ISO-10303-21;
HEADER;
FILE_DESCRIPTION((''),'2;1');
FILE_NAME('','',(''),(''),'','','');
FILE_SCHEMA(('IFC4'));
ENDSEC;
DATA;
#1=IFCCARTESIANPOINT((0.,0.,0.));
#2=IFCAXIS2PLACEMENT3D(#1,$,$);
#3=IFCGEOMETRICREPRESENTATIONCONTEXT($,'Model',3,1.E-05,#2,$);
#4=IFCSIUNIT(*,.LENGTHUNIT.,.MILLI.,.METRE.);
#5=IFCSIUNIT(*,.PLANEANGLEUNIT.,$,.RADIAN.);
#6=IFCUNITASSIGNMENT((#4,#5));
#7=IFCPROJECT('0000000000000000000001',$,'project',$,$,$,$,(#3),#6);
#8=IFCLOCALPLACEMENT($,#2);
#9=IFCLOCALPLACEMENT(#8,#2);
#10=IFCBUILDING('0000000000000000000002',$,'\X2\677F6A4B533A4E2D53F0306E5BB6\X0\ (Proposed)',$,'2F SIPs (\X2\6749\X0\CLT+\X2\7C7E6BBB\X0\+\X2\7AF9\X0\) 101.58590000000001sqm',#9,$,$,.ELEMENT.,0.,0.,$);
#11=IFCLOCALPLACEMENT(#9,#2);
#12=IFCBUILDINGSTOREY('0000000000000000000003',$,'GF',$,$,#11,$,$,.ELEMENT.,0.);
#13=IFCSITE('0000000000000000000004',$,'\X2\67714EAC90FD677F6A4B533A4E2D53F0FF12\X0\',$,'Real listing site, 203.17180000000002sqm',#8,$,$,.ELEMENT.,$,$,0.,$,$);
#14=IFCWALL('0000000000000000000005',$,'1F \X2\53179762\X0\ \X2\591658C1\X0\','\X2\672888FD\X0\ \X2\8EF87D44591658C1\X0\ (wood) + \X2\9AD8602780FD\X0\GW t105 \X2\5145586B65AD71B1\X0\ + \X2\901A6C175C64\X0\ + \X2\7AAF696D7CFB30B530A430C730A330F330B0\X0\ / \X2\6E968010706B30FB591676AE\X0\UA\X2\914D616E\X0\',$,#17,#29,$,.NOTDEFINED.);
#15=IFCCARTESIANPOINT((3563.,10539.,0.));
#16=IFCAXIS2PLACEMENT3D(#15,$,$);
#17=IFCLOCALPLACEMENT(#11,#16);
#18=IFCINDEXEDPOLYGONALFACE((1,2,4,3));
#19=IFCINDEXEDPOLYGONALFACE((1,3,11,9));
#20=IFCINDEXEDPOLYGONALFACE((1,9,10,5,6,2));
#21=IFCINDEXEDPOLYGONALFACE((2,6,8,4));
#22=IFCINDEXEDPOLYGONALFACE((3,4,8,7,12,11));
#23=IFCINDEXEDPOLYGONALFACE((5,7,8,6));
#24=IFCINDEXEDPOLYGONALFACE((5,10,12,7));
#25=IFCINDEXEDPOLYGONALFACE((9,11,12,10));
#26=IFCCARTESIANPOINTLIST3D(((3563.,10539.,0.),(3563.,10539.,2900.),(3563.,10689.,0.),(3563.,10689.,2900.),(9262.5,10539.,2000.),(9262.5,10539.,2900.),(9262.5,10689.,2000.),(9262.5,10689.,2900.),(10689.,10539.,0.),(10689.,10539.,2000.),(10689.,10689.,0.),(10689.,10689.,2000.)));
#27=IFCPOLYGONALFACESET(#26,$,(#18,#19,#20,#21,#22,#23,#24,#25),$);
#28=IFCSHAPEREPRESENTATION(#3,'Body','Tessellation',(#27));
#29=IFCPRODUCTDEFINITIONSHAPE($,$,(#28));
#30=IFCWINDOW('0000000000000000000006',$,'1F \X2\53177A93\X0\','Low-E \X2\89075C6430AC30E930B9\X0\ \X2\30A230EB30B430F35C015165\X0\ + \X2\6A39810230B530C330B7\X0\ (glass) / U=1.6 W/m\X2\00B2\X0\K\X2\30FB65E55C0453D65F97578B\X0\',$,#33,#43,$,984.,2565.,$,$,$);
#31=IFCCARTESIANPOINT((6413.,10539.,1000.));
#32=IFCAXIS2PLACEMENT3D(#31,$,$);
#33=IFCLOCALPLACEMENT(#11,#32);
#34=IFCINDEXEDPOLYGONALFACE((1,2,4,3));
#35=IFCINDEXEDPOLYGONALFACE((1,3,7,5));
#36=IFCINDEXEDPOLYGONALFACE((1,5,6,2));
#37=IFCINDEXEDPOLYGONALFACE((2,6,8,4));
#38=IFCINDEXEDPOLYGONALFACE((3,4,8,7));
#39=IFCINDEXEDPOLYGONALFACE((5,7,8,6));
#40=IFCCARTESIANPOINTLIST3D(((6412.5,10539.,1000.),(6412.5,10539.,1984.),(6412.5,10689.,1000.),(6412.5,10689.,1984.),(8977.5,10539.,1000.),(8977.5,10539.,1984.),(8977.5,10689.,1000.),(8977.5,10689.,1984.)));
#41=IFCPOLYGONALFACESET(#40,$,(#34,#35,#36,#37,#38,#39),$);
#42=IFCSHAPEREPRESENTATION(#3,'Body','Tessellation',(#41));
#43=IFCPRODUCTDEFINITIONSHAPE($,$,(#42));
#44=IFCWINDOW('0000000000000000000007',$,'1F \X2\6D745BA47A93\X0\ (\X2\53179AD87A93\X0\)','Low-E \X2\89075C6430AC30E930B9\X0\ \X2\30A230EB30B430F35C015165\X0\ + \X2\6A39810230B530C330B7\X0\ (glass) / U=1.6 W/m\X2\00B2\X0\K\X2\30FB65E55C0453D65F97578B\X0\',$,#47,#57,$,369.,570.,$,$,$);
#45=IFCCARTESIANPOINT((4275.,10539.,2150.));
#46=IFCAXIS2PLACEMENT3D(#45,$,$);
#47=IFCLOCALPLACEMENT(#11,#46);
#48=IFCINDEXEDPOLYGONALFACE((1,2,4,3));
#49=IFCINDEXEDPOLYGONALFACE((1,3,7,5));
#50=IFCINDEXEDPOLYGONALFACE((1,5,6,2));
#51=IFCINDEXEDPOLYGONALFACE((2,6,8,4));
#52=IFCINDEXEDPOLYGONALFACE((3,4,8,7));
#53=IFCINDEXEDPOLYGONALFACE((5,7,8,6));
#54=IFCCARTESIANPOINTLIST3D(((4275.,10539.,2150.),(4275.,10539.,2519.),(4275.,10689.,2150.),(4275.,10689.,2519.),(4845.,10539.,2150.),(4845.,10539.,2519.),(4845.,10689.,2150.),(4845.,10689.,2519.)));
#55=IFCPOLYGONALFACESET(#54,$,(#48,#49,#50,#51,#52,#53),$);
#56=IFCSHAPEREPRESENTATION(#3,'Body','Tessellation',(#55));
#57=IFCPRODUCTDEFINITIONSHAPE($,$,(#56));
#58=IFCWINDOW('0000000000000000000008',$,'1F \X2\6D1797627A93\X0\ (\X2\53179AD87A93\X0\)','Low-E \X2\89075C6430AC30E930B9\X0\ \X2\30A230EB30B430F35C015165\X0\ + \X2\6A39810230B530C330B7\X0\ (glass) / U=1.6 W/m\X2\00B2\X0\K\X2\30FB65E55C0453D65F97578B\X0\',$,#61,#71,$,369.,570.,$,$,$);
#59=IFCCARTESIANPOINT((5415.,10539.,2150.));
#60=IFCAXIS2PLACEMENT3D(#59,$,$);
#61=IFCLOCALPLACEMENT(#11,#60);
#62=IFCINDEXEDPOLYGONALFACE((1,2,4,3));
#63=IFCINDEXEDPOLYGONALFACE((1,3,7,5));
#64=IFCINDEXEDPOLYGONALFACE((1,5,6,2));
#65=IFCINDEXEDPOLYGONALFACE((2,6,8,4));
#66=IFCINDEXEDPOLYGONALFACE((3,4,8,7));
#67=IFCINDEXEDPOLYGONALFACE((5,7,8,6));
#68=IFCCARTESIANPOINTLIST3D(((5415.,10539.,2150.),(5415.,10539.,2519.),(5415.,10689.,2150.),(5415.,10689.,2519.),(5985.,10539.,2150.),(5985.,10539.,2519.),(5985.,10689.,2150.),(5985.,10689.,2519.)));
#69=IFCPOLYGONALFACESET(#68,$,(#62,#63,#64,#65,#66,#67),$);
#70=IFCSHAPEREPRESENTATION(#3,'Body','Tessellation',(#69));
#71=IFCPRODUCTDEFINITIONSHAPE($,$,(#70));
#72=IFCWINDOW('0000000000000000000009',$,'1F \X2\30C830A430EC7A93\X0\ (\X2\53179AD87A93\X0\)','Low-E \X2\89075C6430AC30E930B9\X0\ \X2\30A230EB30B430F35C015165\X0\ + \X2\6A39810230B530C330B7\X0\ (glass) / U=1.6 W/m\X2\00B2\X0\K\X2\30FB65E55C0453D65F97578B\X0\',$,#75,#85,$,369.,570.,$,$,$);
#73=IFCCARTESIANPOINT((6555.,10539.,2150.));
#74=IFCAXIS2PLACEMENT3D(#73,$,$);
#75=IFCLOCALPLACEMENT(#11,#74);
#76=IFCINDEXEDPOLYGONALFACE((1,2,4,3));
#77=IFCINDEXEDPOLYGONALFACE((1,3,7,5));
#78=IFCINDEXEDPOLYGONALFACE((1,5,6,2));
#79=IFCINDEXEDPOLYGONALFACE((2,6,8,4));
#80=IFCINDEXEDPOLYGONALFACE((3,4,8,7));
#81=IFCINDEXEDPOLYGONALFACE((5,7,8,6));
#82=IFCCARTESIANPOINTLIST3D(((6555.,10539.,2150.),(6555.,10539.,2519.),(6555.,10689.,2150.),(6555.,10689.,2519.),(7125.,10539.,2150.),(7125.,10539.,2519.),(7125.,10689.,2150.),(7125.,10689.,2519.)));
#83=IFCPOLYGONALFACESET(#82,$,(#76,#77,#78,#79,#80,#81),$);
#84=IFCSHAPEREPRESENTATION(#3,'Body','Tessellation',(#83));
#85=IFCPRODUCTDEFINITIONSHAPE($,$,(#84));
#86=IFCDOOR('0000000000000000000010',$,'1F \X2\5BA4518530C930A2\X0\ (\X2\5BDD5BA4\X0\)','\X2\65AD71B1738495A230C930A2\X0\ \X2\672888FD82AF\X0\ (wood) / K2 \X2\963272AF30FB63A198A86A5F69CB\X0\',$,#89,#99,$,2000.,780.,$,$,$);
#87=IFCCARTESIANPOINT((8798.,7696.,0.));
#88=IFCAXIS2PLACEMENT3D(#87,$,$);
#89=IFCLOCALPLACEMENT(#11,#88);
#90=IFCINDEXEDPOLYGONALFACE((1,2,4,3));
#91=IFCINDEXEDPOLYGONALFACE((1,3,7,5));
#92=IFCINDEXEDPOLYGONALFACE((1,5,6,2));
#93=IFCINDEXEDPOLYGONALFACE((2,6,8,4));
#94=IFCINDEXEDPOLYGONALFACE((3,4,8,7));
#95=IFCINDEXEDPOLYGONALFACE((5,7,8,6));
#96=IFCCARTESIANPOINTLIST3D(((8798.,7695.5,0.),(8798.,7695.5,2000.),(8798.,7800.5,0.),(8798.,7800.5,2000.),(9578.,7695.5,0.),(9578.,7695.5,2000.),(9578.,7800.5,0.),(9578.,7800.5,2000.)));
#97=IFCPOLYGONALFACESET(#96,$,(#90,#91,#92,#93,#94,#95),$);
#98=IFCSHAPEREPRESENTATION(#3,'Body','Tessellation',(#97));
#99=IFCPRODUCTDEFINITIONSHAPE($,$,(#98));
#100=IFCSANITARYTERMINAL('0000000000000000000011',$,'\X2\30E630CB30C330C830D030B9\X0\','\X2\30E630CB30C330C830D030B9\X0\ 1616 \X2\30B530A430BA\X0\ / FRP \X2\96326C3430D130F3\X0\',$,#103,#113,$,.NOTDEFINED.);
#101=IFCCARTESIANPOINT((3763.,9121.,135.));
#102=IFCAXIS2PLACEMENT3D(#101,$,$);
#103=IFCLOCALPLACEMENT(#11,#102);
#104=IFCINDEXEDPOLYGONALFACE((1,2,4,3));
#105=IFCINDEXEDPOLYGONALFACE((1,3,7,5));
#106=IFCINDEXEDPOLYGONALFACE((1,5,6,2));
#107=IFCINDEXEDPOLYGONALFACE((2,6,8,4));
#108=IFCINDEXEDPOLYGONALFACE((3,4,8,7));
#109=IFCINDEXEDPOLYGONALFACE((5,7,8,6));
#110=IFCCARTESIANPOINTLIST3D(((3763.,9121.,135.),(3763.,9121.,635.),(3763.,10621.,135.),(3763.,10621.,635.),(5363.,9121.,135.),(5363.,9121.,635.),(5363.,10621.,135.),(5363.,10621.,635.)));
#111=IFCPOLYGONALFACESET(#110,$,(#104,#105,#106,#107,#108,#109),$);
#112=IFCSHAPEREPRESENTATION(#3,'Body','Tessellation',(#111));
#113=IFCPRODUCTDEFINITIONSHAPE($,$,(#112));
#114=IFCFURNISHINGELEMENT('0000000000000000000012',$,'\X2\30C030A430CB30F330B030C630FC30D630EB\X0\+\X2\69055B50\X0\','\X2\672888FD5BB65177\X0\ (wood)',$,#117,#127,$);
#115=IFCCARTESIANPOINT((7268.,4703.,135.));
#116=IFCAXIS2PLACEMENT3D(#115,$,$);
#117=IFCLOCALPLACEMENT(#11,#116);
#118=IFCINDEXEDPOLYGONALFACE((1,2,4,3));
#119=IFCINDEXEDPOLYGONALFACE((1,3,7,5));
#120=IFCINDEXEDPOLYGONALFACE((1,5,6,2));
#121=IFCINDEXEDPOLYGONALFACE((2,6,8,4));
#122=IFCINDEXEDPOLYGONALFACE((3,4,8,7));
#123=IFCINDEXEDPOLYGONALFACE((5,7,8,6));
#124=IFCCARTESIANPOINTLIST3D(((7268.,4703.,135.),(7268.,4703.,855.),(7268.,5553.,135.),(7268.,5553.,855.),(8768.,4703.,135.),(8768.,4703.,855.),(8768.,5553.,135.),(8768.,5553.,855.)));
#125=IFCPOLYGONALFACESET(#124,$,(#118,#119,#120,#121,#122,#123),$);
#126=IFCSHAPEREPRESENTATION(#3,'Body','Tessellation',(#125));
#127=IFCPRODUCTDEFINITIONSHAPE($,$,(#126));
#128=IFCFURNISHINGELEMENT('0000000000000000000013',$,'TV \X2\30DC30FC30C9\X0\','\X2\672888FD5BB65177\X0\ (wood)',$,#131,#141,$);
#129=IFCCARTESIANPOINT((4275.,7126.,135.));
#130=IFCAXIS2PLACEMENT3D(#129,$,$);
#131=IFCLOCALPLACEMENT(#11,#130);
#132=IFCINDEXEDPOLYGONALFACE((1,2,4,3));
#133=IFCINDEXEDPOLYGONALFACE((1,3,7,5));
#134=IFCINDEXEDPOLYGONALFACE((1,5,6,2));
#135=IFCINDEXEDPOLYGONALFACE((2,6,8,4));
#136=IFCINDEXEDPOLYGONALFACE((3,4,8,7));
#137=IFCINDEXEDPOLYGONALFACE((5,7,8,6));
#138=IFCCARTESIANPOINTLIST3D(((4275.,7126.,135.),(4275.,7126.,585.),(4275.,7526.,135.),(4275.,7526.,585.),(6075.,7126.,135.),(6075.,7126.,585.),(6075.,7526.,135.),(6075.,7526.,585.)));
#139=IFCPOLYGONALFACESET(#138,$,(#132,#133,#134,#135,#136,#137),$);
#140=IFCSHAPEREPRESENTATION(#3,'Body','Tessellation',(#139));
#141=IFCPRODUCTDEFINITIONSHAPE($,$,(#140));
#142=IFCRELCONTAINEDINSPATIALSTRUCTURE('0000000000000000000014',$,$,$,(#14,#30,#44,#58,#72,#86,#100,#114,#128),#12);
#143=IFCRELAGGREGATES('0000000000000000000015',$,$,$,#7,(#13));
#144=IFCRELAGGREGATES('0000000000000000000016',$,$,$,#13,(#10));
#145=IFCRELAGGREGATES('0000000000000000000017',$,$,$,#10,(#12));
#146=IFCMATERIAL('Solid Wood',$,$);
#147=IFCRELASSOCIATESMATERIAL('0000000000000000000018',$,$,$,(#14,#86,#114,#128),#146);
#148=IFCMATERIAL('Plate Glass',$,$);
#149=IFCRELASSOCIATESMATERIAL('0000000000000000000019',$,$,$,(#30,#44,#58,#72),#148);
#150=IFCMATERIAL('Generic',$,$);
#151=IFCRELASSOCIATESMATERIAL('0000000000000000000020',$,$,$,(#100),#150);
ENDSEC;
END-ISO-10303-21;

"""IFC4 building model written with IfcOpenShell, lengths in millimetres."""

from ifc_helpers import new_model, si_unit, frame, frame_2d, origin, place, context, project, spatial, rectangle, extrude, material, element, fill, save


model = new_model("IFC4")

# Units and contexts
model_context = context("Model", 3, precision=1e-05, world=origin())
ifc_project = project(units=[si_unit("LENGTHUNIT", "METRE", prefix="MILLI"), si_unit("PLANEANGLEUNIT", "RADIAN")], contexts=[model_context])

# Site, building, storey
site_placement = place(None, origin())
site = spatial("IfcSite", under=ifc_project, at=site_placement, Name="東京都板橋区中台２", ObjectType="Real listing site, 203.17180000000002sqm", CompositionType="ELEMENT", RefElevation=0.0)
building_placement = place(site_placement, origin())
building = spatial("IfcBuilding", under=site, at=building_placement, Name="板橋区中台の家 (Proposed)", ObjectType="2F SIPs (杉CLT+籾殻+竹) 101.58590000000001sqm", CompositionType="ELEMENT", ElevationOfRefHeight=0.0, ElevationOfTerrain=0.0)
storey_placement = place(building_placement, origin())
storey = spatial("IfcBuildingStorey", under=building, at=storey_placement, Name="GF", CompositionType="ELEMENT", Elevation=0.0)

# Wall, openings, windows
ifc_material_1 = material(Name="Solid Wood")
wall_1_placement = place(storey_placement, frame((3563.0, 10539.0, 0.0)))
wall_1 = element("IfcWall", 1, at=wall_1_placement, inside=storey, material=ifc_material_1, Name="1F 北面 外壁", Description="木製 軸組外壁 (wood) + 高性能GW t105 充填断熱 + 通気層 + 窯業系サイディング / 準耐火・外皮UA配慮", PredefinedType="NOTDEFINED", context=model_context, shape_type="SweptSolid", body=[
    extrude(rectangle(XDim=7126.0, YDim=150.0, at=frame_2d((3563.0, 75.0))), frame((3563.0, 10539.0, 0.0)), (0.0, 0.0, 1.0), 2900.0),
])
opening_1_placement = place(storey_placement, frame((6413.0, 10539.0, 1000.0)))
opening_1 = element("IfcOpeningElement", 2, at=opening_1_placement, cuts=wall_1, PredefinedType="NOTDEFINED", context=model_context, shape_type="SweptSolid", body=[
    extrude(rectangle(XDim=2565.0, YDim=150.0, at=frame_2d((1282.0, 75.0))), frame((6413.0, 10539.0, 1000.0)), (0.0, 0.0, 1.0), 984.0),
])
opening_2_placement = place(storey_placement, frame((4275.0, 10539.0, 2150.0)))
opening_2 = element("IfcOpeningElement", 3, at=opening_2_placement, cuts=wall_1, PredefinedType="NOTDEFINED", context=model_context, shape_type="SweptSolid", body=[
    extrude(rectangle(XDim=570.0, YDim=150.0, at=frame_2d((285.0, 75.0))), frame((4275.0, 10539.0, 2150.0)), (0.0, 0.0, 1.0), 369.0),
])
opening_3_placement = place(storey_placement, frame((5415.0, 10539.0, 2150.0)))
opening_3 = element("IfcOpeningElement", 4, at=opening_3_placement, cuts=wall_1, PredefinedType="NOTDEFINED", context=model_context, shape_type="SweptSolid", body=[
    extrude(rectangle(XDim=570.0, YDim=150.0, at=frame_2d((285.0, 75.0))), frame((5415.0, 10539.0, 2150.0)), (0.0, 0.0, 1.0), 369.0),
])
opening_4_placement = place(storey_placement, frame((6555.0, 10539.0, 2150.0)))
opening_4 = element("IfcOpeningElement", 5, at=opening_4_placement, cuts=wall_1, PredefinedType="NOTDEFINED", context=model_context, shape_type="SweptSolid", body=[
    extrude(rectangle(XDim=570.0, YDim=150.0, at=frame_2d((285.0, 75.0))), frame((6555.0, 10539.0, 2150.0)), (0.0, 0.0, 1.0), 369.0),
])
ifc_material_2 = material(Name="Plate Glass")
window_1_placement = place(storey_placement, frame((6413.0, 10539.0, 1000.0)))
window_1 = element("IfcWindow", 6, at=window_1_placement, inside=storey, material=ifc_material_2, Name="1F 北窓", Description="Low-E 複層ガラス アルゴン封入 + 樹脂サッシ (glass) / U=1.6 W/m²K・日射取得型", OverallHeight=984.0, OverallWidth=2565.0, context=model_context, shape_type="SweptSolid", body=[
    extrude(rectangle(XDim=2565.0, YDim=150.0, at=frame_2d((1282.0, 75.0))), frame((6413.0, 10539.0, 1000.0)), (0.0, 0.0, 1.0), 984.0),
])
fill(opening_1, window_1)
window_2_placement = place(storey_placement, frame((4275.0, 10539.0, 2150.0)))
window_2 = element("IfcWindow", 7, at=window_2_placement, inside=storey, material=ifc_material_2, Name="1F 浴室窓 (北高窓)", Description="Low-E 複層ガラス アルゴン封入 + 樹脂サッシ (glass) / U=1.6 W/m²K・日射取得型", OverallHeight=369.0, OverallWidth=570.0, context=model_context, shape_type="SweptSolid", body=[
    extrude(rectangle(XDim=570.0, YDim=150.0, at=frame_2d((285.0, 75.0))), frame((4275.0, 10539.0, 2150.0)), (0.0, 0.0, 1.0), 369.0),
])
fill(opening_2, window_2)
window_3_placement = place(storey_placement, frame((5415.0, 10539.0, 2150.0)))
window_3 = element("IfcWindow", 8, at=window_3_placement, inside=storey, material=ifc_material_2, Name="1F 洗面窓 (北高窓)", Description="Low-E 複層ガラス アルゴン封入 + 樹脂サッシ (glass) / U=1.6 W/m²K・日射取得型", OverallHeight=369.0, OverallWidth=570.0, context=model_context, shape_type="SweptSolid", body=[
    extrude(rectangle(XDim=570.0, YDim=150.0, at=frame_2d((285.0, 75.0))), frame((5415.0, 10539.0, 2150.0)), (0.0, 0.0, 1.0), 369.0),
])
fill(opening_3, window_3)
window_4_placement = place(storey_placement, frame((6555.0, 10539.0, 2150.0)))
window_4 = element("IfcWindow", 9, at=window_4_placement, inside=storey, material=ifc_material_2, Name="1F トイレ窓 (北高窓)", Description="Low-E 複層ガラス アルゴン封入 + 樹脂サッシ (glass) / U=1.6 W/m²K・日射取得型", OverallHeight=369.0, OverallWidth=570.0, context=model_context, shape_type="SweptSolid", body=[
    extrude(rectangle(XDim=570.0, YDim=150.0, at=frame_2d((285.0, 75.0))), frame((6555.0, 10539.0, 2150.0)), (0.0, 0.0, 1.0), 369.0),
])
fill(opening_4, window_4)

# Door
door_1_placement = place(storey_placement, frame((8798.0, 7696.0, 0.0)))
element("IfcDoor", 10, at=door_1_placement, inside=storey, material=ifc_material_1, Name="1F 室内ドア (寝室)", Description="断熱玄関ドア 木製芯 (wood) / K2 防犯・採風機構", OverallHeight=2000.0, OverallWidth=780.0, context=model_context, shape_type="SweptSolid", body=[
    extrude(rectangle(XDim=780.0, YDim=105.0, at=frame_2d((390.0, 52.0))), frame((8798.0, 7696.0, 0.0)), (0.0, 0.0, 1.0), 2000.0),
])

# Sanitary terminal
ifc_material_3 = material(Name="Generic")
sanitary_terminal_placement = place(storey_placement, frame((3763.0, 9121.0, 135.0)))
element("IfcSanitaryTerminal", 11, at=sanitary_terminal_placement, inside=storey, material=ifc_material_3, Name="ユニットバス", Description="ユニットバス 1616 サイズ / FRP 防水パン", PredefinedType="NOTDEFINED", context=model_context, shape_type="SweptSolid", body=[
    extrude(rectangle(XDim=1600.0, YDim=1500.0, at=frame_2d((800.0, 750.0))), frame((3763.0, 9121.0, 135.0)), (0.0, 0.0, 1.0), 500.0),
])

# Furnishing elements
furnishing_1_placement = place(storey_placement, frame((7268.0, 4703.0, 135.0)))
element("IfcFurnishingElement", 12, at=furnishing_1_placement, inside=storey, material=ifc_material_1, Name="ダイニングテーブル+椅子", Description="木製家具 (wood)", context=model_context, shape_type="SweptSolid", body=[
    extrude(rectangle(XDim=1500.0, YDim=850.0, at=frame_2d((750.0, 425.0))), frame((7268.0, 4703.0, 135.0)), (0.0, 0.0, 1.0), 720.0),
])
furnishing_2_placement = place(storey_placement, frame((4275.0, 7126.0, 135.0)))
element("IfcFurnishingElement", 13, at=furnishing_2_placement, inside=storey, material=ifc_material_1, Name="TV ボード", Description="木製家具 (wood)", context=model_context, shape_type="SweptSolid", body=[
    extrude(rectangle(XDim=1800.0, YDim=400.0, at=frame_2d((900.0, 200.0))), frame((4275.0, 7126.0, 135.0)), (0.0, 0.0, 1.0), 450.0),
])

save(model, "model.ifc")
